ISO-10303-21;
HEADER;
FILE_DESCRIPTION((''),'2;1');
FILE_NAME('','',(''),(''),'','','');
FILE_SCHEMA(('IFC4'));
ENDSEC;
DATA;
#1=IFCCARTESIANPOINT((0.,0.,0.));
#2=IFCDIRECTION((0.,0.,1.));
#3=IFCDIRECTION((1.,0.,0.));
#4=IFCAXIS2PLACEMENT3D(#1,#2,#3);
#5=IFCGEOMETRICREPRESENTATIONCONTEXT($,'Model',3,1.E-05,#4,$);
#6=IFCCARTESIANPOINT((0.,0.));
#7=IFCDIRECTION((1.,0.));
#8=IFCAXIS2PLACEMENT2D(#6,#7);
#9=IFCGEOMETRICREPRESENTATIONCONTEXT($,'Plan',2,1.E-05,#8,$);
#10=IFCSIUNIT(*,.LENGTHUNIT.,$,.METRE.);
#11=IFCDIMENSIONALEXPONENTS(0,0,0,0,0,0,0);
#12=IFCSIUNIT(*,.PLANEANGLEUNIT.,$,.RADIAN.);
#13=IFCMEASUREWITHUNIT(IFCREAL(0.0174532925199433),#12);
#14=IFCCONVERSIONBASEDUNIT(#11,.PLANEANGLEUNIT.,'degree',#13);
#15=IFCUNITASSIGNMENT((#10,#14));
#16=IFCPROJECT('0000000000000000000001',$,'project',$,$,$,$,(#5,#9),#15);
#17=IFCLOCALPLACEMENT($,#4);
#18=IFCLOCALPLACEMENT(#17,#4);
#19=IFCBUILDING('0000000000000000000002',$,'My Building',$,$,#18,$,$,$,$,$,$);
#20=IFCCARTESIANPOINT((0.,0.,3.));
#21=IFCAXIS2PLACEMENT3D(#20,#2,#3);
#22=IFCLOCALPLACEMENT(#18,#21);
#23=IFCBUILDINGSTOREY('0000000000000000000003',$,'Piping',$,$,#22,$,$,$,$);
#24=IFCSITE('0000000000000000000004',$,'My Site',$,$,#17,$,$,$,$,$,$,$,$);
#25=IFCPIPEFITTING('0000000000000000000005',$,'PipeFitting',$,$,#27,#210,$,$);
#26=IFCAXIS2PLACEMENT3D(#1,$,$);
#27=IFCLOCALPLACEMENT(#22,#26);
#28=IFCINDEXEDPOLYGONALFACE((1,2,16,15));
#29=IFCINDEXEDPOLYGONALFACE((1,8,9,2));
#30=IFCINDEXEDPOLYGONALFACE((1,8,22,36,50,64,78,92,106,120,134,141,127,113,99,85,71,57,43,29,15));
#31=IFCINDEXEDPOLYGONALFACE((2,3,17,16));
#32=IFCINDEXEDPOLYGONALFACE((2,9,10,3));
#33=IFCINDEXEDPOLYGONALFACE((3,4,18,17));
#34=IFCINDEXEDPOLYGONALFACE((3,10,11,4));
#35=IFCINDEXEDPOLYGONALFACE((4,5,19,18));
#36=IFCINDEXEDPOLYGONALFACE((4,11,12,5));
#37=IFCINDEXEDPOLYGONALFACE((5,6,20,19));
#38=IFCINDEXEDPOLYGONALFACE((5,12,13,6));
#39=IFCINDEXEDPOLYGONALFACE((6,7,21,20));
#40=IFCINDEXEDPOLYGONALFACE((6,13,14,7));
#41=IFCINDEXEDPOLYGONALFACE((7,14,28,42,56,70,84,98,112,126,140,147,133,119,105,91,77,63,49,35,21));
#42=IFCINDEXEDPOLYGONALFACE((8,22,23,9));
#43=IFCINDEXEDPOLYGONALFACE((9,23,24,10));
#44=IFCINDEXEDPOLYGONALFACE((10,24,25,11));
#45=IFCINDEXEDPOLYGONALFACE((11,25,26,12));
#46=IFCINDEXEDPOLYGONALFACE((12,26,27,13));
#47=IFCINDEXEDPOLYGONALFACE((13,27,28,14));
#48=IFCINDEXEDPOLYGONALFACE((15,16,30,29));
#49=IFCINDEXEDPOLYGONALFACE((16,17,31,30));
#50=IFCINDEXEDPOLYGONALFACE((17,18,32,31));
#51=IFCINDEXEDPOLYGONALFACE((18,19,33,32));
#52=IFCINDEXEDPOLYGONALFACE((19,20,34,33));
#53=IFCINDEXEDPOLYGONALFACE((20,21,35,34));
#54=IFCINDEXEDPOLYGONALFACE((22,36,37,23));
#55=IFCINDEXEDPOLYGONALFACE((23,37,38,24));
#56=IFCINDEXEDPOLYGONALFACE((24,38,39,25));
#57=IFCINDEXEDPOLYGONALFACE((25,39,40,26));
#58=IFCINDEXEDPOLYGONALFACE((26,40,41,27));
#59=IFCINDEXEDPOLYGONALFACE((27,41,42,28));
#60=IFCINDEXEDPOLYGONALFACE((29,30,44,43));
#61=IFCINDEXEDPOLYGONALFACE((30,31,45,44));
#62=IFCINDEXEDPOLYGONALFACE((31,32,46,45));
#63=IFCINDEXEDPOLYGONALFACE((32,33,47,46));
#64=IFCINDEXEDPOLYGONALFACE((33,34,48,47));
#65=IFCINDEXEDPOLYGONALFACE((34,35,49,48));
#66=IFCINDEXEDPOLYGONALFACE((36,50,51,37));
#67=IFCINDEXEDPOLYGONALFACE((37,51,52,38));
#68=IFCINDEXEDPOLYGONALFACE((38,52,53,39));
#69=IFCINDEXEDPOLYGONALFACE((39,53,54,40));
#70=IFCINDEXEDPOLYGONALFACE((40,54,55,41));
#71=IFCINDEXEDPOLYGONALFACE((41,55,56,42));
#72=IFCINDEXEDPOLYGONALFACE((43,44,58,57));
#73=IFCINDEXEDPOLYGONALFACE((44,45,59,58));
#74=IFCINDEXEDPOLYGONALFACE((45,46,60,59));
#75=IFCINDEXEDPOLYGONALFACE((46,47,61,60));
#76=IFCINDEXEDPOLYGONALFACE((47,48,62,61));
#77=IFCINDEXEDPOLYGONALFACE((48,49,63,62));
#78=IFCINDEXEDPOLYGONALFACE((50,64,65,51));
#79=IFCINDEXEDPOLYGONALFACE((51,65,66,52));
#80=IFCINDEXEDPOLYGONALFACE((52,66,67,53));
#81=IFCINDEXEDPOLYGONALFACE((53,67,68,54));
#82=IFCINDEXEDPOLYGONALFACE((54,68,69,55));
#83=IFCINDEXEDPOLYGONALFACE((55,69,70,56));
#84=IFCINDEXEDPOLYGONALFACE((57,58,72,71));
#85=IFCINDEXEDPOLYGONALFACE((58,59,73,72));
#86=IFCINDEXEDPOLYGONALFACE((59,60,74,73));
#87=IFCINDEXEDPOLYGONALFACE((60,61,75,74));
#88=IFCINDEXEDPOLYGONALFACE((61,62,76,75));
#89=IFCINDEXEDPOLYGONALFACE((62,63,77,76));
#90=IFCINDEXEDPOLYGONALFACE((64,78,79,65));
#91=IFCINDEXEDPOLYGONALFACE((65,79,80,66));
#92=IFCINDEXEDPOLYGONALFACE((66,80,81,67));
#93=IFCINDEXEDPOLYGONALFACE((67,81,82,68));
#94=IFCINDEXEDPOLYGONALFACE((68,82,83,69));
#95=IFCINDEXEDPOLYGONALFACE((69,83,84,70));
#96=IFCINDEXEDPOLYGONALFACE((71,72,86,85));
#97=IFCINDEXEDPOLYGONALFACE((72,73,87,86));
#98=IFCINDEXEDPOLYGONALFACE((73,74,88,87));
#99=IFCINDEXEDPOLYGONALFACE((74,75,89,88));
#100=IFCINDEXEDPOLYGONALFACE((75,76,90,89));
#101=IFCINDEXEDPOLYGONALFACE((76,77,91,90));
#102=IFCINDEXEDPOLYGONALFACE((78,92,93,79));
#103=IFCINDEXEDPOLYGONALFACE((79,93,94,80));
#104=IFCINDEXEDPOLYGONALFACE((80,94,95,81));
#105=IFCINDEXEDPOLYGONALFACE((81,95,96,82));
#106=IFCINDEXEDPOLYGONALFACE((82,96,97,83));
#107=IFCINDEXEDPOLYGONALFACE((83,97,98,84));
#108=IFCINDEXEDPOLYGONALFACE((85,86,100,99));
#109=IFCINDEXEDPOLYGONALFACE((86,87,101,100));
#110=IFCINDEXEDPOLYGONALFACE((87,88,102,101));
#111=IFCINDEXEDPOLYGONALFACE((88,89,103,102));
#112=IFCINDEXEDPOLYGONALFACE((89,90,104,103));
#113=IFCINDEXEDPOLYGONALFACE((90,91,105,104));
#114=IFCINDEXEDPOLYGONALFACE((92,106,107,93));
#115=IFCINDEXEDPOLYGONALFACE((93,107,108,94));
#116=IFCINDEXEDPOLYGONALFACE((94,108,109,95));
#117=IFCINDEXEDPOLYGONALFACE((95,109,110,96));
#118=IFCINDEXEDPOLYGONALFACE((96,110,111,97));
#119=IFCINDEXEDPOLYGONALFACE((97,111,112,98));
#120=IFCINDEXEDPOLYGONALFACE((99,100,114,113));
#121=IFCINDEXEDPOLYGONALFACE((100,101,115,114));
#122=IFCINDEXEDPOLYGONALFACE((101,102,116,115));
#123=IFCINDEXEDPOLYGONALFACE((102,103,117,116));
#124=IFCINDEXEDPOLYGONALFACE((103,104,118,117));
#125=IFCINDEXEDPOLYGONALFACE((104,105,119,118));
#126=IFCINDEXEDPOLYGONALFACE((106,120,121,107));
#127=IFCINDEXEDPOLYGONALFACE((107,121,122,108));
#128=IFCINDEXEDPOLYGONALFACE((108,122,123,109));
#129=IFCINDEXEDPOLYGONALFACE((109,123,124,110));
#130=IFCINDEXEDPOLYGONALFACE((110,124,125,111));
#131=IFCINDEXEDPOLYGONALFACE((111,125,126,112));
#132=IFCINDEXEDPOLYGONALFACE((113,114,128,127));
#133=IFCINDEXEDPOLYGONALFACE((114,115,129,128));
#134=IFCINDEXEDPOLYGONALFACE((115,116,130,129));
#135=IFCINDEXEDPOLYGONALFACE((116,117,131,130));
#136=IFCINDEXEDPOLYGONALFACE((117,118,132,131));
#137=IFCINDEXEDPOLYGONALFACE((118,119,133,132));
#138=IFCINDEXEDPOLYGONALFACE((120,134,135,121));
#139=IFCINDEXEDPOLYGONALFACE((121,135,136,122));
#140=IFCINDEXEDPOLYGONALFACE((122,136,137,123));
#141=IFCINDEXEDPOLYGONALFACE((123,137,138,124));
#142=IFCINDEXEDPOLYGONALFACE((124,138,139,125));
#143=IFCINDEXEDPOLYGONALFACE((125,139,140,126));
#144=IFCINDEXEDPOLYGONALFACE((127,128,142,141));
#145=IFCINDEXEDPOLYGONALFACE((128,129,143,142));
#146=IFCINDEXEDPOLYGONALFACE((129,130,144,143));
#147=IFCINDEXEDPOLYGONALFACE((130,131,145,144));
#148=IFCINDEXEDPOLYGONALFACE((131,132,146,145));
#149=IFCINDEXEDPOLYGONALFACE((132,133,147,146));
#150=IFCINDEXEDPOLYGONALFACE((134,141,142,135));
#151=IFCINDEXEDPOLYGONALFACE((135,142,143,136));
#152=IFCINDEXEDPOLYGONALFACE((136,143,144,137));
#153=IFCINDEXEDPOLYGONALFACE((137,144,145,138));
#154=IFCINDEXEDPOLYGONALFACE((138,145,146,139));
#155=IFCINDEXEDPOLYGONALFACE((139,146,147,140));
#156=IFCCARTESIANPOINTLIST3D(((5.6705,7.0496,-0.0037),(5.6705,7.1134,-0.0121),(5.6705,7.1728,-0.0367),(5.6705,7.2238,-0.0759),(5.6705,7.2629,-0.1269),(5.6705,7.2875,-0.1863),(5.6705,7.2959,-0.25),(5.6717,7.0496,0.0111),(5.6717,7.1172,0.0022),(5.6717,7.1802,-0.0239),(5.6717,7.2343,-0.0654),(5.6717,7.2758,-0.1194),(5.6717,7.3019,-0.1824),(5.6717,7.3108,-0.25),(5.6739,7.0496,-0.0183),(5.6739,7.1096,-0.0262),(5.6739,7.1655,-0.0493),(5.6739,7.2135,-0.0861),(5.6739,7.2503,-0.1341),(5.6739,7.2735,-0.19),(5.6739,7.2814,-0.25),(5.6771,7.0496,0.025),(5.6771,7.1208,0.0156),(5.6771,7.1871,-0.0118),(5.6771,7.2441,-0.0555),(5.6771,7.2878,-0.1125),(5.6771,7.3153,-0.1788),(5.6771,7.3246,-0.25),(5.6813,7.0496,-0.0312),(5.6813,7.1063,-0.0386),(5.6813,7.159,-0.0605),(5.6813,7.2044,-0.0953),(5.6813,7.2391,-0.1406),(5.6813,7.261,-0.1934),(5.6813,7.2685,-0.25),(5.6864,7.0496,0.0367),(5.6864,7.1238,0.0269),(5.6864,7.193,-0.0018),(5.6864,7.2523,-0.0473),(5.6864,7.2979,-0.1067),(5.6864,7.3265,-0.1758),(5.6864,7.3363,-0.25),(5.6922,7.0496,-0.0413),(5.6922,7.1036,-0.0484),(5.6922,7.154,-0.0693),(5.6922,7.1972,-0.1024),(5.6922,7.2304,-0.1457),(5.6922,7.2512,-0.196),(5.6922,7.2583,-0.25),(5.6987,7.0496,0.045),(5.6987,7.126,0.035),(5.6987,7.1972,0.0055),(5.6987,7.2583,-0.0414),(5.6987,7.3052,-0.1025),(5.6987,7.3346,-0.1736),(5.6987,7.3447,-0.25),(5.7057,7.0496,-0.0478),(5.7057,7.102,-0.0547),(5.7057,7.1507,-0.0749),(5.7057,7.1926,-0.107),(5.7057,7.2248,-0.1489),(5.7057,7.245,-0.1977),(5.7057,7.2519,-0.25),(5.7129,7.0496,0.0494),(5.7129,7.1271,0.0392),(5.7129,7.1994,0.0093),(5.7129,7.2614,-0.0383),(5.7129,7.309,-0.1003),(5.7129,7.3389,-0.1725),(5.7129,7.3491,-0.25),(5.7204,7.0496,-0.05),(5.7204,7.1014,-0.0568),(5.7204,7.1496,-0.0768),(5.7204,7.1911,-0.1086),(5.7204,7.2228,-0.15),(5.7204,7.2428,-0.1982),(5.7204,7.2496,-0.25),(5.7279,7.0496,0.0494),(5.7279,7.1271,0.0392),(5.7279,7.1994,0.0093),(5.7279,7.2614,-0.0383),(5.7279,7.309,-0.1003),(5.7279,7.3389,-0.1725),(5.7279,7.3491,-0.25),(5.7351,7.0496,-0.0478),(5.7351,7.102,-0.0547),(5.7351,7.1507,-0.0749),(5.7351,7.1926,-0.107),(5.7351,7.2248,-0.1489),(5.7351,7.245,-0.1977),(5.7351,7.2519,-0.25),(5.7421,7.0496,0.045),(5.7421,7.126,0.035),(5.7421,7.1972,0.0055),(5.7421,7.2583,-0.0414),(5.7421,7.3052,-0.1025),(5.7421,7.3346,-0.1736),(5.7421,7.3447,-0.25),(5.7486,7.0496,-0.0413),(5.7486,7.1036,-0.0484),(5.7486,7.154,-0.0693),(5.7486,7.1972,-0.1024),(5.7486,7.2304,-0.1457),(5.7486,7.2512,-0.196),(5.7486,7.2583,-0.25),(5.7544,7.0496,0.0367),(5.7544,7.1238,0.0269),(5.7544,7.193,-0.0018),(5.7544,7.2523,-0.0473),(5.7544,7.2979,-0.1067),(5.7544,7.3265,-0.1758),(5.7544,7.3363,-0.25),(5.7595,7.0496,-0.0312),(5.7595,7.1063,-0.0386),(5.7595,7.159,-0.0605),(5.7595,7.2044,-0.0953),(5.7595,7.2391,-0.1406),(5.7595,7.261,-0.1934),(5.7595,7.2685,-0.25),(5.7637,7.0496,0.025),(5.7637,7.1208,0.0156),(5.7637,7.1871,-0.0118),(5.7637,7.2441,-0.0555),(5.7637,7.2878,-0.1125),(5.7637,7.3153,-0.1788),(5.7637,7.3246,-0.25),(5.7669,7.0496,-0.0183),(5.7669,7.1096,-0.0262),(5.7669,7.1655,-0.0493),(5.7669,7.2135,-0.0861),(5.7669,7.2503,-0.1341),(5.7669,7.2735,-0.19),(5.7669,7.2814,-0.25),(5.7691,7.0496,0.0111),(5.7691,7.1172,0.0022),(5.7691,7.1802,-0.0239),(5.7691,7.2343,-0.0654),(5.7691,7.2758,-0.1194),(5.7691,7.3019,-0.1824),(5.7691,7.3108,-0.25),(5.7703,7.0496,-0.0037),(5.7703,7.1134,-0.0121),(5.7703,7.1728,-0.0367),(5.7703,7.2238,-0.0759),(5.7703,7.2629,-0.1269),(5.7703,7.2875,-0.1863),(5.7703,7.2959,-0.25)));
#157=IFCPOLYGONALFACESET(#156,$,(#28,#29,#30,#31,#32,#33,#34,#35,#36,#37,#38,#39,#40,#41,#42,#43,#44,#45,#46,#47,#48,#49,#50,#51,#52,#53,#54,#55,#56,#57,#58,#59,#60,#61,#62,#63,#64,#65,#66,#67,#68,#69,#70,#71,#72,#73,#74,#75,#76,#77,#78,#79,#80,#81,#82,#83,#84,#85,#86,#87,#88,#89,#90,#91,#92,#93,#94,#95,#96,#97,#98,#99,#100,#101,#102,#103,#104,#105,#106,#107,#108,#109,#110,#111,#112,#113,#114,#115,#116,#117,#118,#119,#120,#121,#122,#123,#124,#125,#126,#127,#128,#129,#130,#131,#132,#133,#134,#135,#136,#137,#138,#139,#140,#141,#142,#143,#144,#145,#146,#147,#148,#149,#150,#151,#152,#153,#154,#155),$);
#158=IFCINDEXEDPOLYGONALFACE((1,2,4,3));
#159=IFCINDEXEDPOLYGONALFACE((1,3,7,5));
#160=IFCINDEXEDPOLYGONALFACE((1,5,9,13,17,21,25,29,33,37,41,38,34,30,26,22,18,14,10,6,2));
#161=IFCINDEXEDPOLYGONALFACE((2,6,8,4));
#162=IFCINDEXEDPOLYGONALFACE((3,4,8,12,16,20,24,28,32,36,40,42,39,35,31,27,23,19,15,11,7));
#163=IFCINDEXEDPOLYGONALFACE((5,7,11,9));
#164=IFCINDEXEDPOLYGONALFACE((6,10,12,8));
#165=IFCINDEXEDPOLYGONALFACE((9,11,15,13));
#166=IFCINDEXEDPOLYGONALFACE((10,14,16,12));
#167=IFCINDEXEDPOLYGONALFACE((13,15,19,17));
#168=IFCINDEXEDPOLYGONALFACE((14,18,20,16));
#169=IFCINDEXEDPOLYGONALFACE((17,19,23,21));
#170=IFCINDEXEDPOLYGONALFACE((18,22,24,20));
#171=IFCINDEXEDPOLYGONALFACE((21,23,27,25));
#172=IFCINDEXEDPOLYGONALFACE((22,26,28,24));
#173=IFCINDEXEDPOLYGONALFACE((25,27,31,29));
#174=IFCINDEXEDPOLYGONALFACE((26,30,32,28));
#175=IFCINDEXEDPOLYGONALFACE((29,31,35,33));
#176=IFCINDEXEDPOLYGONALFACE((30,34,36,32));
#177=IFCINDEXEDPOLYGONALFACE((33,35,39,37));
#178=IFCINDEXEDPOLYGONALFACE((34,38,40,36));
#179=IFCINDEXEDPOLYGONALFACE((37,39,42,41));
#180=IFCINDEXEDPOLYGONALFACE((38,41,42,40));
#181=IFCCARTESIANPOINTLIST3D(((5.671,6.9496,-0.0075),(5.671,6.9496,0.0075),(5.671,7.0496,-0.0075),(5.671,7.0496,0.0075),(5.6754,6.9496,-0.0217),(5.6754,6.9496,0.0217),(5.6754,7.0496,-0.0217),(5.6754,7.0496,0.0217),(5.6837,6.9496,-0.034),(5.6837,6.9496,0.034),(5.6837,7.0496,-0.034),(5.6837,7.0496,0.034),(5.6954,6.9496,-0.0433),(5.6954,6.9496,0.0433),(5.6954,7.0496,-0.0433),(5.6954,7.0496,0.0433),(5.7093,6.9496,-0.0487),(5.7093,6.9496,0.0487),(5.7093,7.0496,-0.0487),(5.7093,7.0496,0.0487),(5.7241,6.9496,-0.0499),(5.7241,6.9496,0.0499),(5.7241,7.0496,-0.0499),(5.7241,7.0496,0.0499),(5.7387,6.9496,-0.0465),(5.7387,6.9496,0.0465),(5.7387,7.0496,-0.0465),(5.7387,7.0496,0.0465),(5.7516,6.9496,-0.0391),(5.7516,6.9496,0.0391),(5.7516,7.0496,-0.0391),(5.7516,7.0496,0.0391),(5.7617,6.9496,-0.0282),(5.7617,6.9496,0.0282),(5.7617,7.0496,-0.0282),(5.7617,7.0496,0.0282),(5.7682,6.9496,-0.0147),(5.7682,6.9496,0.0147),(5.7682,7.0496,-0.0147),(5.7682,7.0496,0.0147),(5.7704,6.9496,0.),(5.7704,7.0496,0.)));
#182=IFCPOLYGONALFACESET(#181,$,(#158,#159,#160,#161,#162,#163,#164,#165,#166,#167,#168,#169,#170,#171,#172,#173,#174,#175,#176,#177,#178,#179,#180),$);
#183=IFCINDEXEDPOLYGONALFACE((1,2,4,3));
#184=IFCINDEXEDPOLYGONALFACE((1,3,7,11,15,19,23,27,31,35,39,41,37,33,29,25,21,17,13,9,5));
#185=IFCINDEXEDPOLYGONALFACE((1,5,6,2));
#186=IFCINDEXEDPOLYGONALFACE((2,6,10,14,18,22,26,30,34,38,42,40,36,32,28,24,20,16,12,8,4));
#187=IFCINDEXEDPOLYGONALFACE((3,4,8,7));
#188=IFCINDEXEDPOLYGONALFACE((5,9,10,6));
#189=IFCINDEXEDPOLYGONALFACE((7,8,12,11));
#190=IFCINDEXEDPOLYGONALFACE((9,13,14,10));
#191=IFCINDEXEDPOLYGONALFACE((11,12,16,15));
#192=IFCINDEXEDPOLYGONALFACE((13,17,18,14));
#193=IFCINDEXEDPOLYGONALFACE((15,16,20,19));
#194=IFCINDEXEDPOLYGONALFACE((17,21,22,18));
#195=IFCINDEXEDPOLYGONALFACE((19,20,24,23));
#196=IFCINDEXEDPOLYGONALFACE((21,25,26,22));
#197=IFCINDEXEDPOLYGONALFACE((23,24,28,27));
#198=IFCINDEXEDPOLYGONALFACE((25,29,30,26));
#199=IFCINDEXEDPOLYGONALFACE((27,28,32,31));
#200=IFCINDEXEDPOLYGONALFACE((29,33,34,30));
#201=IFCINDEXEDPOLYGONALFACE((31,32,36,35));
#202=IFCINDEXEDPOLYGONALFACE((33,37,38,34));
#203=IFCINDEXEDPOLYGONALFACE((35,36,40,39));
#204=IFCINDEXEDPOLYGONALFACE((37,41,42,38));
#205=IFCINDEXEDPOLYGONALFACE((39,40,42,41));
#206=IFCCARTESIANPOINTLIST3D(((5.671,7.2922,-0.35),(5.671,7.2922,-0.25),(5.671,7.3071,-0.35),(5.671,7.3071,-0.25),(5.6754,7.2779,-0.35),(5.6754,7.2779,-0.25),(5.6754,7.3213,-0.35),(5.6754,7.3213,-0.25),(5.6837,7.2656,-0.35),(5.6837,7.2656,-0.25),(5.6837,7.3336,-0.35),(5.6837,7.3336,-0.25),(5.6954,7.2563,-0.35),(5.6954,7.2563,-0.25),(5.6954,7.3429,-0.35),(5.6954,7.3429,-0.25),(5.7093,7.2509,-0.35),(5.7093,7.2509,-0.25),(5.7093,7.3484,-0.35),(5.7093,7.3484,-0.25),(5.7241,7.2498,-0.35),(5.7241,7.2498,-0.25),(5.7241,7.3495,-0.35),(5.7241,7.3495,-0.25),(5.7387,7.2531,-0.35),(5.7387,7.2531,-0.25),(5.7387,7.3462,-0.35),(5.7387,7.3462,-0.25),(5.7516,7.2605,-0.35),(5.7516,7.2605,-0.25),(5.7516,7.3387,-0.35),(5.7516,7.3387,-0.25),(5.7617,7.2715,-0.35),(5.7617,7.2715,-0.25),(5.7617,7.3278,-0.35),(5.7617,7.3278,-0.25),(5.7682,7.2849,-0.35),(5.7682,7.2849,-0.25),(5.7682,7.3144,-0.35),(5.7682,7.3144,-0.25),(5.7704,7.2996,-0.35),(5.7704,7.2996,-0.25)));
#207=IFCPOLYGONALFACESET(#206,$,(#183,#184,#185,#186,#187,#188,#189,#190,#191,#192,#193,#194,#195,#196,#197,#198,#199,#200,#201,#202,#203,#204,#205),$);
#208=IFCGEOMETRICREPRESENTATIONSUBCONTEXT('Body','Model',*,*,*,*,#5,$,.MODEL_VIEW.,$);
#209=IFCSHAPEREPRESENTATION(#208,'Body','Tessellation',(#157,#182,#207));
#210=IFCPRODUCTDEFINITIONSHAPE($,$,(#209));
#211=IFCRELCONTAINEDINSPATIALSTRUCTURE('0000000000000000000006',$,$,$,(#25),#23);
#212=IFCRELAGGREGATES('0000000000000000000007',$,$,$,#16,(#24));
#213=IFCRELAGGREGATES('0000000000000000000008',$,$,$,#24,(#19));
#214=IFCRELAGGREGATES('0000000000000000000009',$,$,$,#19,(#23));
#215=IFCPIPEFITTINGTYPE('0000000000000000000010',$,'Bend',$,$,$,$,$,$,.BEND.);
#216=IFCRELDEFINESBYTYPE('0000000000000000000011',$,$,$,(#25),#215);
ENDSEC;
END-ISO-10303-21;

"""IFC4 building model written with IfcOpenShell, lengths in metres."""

from ifc_helpers import new_model, entity, si_unit, converted_unit, frame, origin_with_axes, origin_2d_with_axis, place, context, subcontext, project, spatial, circle, extrude, source, transform, mapped, type_object, type_shapes, element, save


model = new_model("IFC4")

# Units and contexts
model_context = context("Model", 3, precision=1e-05, world=origin_with_axes())
plan_context = context("Plan", 2, precision=1e-05, world=origin_2d_with_axis())
body_context = subcontext(model_context, "Body", "Model", "MODEL_VIEW")
ifc_project = project(units=[si_unit("LENGTHUNIT", "METRE"), converted_unit("PLANEANGLEUNIT", "degree", entity("IfcReal", 0.0174532925199433), si_unit("PLANEANGLEUNIT", "RADIAN"), dimensions=[0, 0, 0, 0, 0, 0, 0])], contexts=[model_context, plan_context])

# Site, building, storey
site_placement = place(None, origin_with_axes())
site = spatial("IfcSite", under=ifc_project, at=site_placement, Name="My Site")
building_placement = place(site_placement, origin_with_axes())
building = spatial("IfcBuilding", under=site, at=building_placement, Name="My Building")
storey_placement = place(building_placement, frame((0.0, 0.0, 3.0), z_axis=(0.0, 0.0, 1.0), x_axis=(1.0, 0.0, 0.0)))
storey = spatial("IfcBuildingStorey", under=building, at=storey_placement, Name="Piping")

# Pipe fitting
pipe_fitting_type = type_object("IfcPipeFittingType", Name="Bend", PredefinedType="BEND")
shared_shape = source(origin_with_axes(), body_context, "Body", "SolidModel", [
    entity("IfcSweptDiskSolid", entity("IfcIndexedPolyCurve", entity("IfcCartesianPointList3D", [[0.0, 0.0, -0.1], [0.0, -0.0732, -0.2768], [0.0, -0.25, -0.35]]), [entity("IfcArcIndex", [1, 2, 3])]), 0.05),
    extrude(circle(Radius=0.05), origin_with_axes(), (0.0, 0.0, -1.0), 0.1),
    extrude(circle(Radius=0.05), frame((0.0, -0.25, -0.35), z_axis=(0.0, -1.0, 0.0), x_axis=(1.0, 0.0, 0.0)), (0.0, 0.0, 1.0), 0.1),
])
type_shapes(pipe_fitting_type, [shared_shape])
for number, where, z_axis, x_axis, name in (
    (1, (5.7204, 6.9496, 0.0), (0.0, -1.0, 0.0), (1.0, 0.0, 0.0), "PipeFitting"),
):
    element("IfcPipeFitting", number, at=place(storey_placement, frame(where, z_axis=z_axis, x_axis=x_axis)), inside=storey, type_object=pipe_fitting_type, Name=name, context=body_context, shape_type="MappedRepresentation", body=[
        mapped(shared_shape, transform((0.0, 0.0, 0.0), x_axis=(1.0, 0.0, 0.0), y_axis=(0.0, 1.0, 0.0), z_axis=(0.0, 0.0, 1.0), scale=1.0)),
    ])

save(model, "model.ifc")
